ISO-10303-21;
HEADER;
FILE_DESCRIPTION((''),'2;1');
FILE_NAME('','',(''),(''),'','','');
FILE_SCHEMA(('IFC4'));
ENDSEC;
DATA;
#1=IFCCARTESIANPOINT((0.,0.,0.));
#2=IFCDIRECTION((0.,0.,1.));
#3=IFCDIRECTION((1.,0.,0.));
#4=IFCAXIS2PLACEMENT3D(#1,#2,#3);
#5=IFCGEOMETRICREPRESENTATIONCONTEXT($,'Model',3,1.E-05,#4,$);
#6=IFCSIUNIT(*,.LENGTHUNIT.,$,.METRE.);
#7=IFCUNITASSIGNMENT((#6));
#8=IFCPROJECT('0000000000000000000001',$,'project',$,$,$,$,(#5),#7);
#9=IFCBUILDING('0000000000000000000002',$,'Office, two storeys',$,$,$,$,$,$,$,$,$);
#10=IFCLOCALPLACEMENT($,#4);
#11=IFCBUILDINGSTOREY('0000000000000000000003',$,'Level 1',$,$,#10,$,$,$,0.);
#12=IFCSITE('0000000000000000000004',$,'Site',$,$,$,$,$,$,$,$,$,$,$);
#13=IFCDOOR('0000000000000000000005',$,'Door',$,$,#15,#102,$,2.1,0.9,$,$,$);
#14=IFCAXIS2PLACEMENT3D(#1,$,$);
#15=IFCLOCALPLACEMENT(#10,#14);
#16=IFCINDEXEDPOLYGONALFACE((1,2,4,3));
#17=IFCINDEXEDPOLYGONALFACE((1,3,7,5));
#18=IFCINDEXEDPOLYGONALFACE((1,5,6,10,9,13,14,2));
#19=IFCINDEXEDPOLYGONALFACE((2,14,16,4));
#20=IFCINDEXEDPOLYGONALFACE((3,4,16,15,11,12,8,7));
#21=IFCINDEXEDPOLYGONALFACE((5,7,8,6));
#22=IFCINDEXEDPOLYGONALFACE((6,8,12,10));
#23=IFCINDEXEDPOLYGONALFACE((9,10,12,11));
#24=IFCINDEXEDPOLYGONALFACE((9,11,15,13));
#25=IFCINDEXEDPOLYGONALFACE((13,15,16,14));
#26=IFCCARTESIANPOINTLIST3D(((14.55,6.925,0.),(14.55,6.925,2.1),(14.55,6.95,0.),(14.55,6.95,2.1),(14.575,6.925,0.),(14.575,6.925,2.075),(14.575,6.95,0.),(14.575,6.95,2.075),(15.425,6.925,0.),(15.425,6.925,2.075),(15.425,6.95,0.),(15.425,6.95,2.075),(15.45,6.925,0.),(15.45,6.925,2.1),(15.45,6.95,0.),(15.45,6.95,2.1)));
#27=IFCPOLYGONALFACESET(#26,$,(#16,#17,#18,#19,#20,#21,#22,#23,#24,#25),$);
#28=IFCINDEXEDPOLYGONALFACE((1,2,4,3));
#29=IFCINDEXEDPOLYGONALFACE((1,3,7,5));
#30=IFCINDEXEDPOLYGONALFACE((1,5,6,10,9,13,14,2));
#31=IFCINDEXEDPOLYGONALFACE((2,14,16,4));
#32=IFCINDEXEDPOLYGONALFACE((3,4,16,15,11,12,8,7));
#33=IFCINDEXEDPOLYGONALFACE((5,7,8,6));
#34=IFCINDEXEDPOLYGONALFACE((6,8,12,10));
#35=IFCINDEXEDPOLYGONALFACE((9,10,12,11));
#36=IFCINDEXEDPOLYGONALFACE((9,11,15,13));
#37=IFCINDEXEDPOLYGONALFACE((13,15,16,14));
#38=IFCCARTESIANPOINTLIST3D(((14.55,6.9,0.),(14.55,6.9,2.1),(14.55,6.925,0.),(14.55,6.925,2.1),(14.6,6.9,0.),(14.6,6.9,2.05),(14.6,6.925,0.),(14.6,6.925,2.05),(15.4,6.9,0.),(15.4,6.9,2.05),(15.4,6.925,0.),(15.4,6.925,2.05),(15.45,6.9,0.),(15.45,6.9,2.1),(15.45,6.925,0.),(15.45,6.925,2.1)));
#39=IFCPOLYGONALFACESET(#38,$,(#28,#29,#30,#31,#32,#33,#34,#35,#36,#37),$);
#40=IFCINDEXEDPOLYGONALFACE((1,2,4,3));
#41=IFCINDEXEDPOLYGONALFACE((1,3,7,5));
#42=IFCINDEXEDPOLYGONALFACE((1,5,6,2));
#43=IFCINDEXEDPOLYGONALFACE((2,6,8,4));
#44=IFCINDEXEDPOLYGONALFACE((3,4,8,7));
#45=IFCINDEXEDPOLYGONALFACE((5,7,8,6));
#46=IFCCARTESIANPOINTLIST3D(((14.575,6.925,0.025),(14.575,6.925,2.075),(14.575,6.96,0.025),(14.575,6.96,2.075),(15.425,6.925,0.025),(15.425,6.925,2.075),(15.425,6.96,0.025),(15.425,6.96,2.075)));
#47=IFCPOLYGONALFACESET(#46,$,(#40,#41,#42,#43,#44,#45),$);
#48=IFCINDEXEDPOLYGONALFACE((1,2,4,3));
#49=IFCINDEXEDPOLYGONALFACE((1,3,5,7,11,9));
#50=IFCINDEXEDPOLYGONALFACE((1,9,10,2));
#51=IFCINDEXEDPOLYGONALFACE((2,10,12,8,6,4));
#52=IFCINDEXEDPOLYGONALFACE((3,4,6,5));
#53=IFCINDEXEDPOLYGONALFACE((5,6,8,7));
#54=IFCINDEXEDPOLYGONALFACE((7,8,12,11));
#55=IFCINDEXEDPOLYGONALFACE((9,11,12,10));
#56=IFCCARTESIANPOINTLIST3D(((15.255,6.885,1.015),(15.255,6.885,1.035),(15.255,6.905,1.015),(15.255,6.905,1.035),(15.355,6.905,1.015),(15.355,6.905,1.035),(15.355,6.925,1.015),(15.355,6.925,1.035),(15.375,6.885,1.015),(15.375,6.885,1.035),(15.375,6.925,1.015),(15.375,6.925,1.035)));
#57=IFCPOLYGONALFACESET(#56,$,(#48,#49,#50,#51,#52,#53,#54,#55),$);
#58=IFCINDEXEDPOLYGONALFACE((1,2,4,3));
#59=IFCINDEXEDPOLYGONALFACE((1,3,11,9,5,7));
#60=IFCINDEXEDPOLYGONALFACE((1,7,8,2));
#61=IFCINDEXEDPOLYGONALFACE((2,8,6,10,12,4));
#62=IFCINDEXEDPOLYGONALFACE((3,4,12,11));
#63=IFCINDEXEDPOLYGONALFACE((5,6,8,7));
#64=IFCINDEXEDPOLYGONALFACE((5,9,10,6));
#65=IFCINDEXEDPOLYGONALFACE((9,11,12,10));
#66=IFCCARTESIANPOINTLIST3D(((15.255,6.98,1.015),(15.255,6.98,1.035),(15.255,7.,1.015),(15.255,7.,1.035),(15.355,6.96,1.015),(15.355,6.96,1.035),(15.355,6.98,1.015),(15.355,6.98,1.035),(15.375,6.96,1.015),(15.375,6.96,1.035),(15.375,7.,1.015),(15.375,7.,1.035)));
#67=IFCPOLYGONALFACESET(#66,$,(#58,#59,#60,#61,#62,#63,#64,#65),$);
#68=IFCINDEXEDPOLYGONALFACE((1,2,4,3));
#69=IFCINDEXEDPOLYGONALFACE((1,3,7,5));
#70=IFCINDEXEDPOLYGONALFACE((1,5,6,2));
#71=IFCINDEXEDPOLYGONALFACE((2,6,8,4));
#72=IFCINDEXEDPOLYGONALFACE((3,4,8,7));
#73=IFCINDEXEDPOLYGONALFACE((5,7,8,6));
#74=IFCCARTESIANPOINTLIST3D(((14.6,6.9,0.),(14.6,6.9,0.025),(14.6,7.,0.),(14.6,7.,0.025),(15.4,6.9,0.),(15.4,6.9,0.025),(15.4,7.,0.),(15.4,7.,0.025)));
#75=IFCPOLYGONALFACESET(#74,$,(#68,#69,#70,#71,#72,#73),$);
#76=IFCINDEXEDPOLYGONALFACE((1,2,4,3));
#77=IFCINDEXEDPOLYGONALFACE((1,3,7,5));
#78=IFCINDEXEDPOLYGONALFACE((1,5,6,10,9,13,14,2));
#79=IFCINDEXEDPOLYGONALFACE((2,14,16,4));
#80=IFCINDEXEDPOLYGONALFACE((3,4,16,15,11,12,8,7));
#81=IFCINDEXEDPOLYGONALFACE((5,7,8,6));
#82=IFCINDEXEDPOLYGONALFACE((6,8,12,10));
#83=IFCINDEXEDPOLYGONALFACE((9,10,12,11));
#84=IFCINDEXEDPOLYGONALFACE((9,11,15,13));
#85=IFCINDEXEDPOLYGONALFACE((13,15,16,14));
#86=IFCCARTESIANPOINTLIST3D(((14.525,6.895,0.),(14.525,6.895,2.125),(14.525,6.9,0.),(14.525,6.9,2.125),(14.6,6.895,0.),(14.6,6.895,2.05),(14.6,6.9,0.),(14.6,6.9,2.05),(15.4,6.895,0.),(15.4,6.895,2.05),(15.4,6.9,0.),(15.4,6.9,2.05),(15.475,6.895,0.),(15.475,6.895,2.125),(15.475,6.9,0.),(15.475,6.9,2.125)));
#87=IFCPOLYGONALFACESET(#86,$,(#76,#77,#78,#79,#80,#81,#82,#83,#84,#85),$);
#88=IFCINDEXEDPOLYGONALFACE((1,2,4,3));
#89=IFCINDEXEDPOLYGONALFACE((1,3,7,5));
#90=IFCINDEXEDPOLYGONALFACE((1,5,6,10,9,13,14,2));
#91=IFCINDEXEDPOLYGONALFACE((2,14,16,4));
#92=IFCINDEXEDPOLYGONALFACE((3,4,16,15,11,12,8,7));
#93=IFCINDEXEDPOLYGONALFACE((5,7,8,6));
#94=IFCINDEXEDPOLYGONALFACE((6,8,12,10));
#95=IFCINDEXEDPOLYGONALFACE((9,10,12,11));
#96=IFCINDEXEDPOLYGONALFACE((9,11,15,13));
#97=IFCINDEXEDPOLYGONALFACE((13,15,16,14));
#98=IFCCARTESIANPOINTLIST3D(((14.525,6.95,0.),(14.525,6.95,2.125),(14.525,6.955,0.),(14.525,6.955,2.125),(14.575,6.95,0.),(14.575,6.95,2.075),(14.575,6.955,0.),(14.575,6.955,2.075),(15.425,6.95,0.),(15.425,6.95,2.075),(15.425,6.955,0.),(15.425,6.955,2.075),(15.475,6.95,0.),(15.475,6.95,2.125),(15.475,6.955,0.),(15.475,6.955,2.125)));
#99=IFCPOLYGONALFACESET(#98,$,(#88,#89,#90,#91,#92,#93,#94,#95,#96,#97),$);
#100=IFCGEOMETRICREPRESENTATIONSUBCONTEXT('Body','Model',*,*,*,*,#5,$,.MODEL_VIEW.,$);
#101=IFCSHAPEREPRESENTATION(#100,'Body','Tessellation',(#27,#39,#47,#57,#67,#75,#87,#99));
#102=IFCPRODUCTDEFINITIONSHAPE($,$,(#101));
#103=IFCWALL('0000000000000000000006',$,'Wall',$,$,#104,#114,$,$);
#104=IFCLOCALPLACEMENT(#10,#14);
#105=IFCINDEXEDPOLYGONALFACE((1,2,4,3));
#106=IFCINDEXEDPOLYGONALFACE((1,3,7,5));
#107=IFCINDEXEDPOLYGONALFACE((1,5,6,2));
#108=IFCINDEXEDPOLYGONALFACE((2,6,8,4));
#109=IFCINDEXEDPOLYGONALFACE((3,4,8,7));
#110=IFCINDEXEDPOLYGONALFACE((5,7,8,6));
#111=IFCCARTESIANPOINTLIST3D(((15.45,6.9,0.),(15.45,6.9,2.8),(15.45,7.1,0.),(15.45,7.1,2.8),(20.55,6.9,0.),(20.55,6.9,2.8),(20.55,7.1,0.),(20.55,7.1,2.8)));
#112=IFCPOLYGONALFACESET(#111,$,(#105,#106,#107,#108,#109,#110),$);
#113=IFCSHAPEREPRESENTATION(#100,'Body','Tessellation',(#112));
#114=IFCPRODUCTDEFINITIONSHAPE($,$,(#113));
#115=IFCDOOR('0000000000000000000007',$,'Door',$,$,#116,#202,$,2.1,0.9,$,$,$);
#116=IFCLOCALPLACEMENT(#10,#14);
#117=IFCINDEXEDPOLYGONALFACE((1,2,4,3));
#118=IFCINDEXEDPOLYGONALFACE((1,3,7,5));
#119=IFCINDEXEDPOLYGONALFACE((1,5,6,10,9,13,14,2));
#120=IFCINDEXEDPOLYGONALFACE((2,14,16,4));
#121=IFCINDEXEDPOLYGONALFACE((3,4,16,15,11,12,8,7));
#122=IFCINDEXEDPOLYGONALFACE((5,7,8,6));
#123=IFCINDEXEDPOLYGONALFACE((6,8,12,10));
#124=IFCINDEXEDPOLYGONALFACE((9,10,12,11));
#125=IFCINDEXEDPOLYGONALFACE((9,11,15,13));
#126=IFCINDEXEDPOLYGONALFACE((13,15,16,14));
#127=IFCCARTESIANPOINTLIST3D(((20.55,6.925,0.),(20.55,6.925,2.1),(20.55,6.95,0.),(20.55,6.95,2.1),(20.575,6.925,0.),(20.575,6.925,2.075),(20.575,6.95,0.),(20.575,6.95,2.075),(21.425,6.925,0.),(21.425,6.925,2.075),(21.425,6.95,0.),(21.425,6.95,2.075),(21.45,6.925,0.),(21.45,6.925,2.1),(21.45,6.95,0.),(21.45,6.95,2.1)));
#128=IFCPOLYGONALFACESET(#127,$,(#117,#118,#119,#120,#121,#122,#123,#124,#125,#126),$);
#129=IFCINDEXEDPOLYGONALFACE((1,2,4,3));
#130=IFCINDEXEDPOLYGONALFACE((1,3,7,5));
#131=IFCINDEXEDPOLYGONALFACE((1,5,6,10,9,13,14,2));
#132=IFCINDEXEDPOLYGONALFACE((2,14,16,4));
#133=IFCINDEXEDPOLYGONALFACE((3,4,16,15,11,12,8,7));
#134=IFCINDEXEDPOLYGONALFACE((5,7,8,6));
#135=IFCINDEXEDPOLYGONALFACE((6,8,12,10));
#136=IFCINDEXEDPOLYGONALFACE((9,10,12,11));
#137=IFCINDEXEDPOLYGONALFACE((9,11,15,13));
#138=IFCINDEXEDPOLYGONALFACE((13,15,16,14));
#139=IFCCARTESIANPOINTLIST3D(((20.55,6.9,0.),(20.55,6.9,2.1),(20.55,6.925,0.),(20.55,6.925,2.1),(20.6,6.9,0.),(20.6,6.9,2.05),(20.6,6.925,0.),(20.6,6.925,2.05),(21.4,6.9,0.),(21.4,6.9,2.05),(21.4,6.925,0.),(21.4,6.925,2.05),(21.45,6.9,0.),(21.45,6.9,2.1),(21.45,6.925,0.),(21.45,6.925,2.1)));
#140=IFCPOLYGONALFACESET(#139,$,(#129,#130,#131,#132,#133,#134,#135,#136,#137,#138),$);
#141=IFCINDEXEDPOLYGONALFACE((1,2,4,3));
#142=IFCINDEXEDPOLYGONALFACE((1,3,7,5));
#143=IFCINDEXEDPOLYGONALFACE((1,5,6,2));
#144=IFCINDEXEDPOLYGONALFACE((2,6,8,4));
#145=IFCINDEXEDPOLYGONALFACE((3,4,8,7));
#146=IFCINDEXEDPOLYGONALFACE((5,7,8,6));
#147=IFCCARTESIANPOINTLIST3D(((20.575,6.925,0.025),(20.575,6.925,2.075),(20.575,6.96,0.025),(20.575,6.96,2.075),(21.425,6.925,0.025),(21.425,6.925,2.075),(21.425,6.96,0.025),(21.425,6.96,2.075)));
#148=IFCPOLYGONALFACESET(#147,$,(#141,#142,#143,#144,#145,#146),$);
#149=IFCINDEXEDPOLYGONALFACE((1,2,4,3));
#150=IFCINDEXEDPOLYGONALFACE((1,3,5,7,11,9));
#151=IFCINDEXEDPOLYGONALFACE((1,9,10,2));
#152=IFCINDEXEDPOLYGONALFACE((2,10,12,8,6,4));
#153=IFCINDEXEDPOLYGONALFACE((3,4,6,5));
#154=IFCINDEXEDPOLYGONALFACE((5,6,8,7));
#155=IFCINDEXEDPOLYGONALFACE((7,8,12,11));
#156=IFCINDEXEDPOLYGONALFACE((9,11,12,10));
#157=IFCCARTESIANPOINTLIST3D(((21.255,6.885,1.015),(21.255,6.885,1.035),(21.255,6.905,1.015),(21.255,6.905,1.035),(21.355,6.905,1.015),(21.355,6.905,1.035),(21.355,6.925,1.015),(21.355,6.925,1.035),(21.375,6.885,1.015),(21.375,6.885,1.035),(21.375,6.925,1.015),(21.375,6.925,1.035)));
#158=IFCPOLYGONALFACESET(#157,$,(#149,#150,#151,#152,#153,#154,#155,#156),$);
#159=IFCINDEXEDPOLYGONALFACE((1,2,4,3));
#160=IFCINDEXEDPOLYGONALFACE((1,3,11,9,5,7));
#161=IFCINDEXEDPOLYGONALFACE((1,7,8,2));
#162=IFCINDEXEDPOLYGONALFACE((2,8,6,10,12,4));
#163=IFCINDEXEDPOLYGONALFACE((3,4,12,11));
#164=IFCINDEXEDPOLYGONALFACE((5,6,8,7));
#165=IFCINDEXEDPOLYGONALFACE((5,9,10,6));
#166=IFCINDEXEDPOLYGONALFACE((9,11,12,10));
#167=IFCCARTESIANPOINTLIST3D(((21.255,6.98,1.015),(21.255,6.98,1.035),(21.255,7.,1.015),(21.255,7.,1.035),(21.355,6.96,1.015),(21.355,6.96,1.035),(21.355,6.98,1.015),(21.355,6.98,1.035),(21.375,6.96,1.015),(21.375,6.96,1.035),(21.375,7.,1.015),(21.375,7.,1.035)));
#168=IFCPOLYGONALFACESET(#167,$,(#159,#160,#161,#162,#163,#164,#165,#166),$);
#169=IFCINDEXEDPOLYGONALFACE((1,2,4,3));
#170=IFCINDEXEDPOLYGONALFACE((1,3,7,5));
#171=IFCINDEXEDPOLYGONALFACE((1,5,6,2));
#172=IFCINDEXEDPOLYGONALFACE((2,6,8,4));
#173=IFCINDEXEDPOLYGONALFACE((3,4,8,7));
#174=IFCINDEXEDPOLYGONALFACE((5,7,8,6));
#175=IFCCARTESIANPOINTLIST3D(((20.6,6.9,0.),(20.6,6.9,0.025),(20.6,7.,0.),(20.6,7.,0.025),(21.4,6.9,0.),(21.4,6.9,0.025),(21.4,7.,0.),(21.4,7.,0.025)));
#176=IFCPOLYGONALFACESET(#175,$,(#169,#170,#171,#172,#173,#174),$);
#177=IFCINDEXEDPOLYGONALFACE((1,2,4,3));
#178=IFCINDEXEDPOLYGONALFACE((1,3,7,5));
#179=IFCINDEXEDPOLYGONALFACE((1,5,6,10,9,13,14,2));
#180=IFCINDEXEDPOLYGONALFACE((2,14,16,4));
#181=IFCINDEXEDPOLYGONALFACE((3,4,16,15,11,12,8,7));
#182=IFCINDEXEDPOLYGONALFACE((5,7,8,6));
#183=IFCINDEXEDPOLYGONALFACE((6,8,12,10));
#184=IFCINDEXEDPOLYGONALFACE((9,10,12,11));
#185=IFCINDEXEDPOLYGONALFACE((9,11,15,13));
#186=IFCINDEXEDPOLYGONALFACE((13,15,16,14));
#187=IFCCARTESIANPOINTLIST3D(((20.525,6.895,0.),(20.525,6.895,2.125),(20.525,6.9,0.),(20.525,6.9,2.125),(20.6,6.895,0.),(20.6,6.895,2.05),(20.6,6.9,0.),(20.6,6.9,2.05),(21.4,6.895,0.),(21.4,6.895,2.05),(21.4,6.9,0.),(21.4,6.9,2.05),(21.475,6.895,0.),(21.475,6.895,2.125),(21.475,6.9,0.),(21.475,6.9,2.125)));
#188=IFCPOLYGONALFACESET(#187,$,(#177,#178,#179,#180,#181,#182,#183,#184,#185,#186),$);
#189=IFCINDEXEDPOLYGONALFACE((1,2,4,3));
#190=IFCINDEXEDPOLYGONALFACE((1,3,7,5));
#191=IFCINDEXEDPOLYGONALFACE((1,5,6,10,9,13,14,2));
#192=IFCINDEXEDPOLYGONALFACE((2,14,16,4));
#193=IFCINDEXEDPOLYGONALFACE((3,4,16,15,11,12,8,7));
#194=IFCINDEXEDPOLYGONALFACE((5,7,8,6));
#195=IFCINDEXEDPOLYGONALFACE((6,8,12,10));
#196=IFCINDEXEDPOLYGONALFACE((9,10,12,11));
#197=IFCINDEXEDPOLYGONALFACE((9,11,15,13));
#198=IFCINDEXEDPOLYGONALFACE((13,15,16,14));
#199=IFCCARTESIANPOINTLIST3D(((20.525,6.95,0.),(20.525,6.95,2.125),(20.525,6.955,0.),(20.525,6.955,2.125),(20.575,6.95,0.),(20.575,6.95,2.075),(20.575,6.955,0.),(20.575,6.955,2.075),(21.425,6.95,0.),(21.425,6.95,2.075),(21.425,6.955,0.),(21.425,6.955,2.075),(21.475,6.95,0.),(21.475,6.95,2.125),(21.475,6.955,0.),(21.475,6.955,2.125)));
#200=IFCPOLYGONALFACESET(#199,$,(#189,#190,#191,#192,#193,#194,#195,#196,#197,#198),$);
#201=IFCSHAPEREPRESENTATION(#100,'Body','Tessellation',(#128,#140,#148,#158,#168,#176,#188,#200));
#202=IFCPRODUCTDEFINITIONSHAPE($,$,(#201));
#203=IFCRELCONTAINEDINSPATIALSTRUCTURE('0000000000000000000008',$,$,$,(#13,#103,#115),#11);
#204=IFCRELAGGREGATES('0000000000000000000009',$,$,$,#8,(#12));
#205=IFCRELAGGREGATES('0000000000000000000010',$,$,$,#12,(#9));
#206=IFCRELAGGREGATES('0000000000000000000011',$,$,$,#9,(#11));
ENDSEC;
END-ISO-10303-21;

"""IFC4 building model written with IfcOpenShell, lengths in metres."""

from ifc_helpers import new_model, si_unit, frame, origin_with_axes, place, context, subcontext, project, spatial, line, indexed_curve, outline, extrude, element, save


model = new_model("IFC4")

# Units and contexts
model_context = context("Model", 3, precision=1e-05, world=origin_with_axes())
body_context = subcontext(model_context, "Body", "Model", "MODEL_VIEW")
ifc_project = project(units=[si_unit("LENGTHUNIT", "METRE")], contexts=[model_context])

# Site, building, storey
site = spatial("IfcSite", under=ifc_project, Name="Site")
building = spatial("IfcBuilding", under=site, Name="Office, two storeys")
storey_placement = place(None, origin_with_axes())
storey = spatial("IfcBuildingStorey", under=building, at=storey_placement, Name="Level 1", Elevation=0.0)

# Door
door_1_placement = place(storey_placement, frame((14.55, 6.9, 0.0), z_axis=(0.0, 0.0, 1.0), x_axis=(1.0, 0.0, 0.0)))
element("IfcDoor", 1, at=door_1_placement, inside=storey, Name="Door", OverallHeight=2.1, OverallWidth=0.9, context=body_context, shape_type="SweptSolid", body=[
    extrude(outline(indexed_curve([(0.0, 0.0), (0.0, 2.1), (0.9, 2.1), (0.9, 0.0), (0.875, 0.0), (0.875, 2.075), (0.025, 2.075), (0.025, 0.0)], segments=[line(1, 2, 3, 4, 5, 6, 7, 8, 1)])), frame((0.0, 0.025, 0.0), z_axis=(0.0, -1.0, 0.0), x_axis=(1.0, 0.0, 0.0)), (0.0, 0.0, -1.0), 0.025),
    extrude(outline(indexed_curve([(0.0, 0.0), (0.0, 2.1), (0.9, 2.1), (0.9, 0.0), (0.85, 0.0), (0.85, 2.05), (0.05, 2.05), (0.05, 0.0)], segments=[line(1, 2, 3, 4, 5, 6, 7, 8, 1)])), frame((0.0, 0.0, 0.0), z_axis=(0.0, -1.0, 0.0), x_axis=(1.0, 0.0, 0.0)), (0.0, 0.0, -1.0), 0.025),
    extrude(outline(indexed_curve([(0.0, 0.0), (0.85, 0.0), (0.85, 0.035), (0.0, 0.035)], segments=[line(1, 2, 3, 4, 1)])), frame((0.025, 0.025, 0.025), z_axis=(0.0, 0.0, 1.0), x_axis=(1.0, 0.0, 0.0)), (0.0, 0.0, 1.0), 2.05),
    extrude(outline(indexed_curve([(0.0, 0.0), (0.0, -0.04), (-0.12, -0.04), (-0.12, -0.02), (-0.02, -0.02), (-0.02, 0.0)], segments=[line(1, 2, 3, 4, 5, 6, 1)])), frame((0.825, 0.025, 1.015), z_axis=(0.0, 0.0, 1.0), x_axis=(1.0, 0.0, 0.0)), (0.0, 0.0, 1.0), 0.02),
    extrude(outline(indexed_curve([(0.0, 0.0), (0.0, 0.04), (-0.12, 0.04), (-0.12, 0.02), (-0.02, 0.02), (-0.02, 0.0)], segments=[line(1, 2, 3, 4, 5, 6, 1)])), frame((0.825, 0.06, 1.015), z_axis=(0.0, 0.0, 1.0), x_axis=(1.0, 0.0, 0.0)), (0.0, 0.0, 1.0), 0.02),
    extrude(outline(indexed_curve([(0.0, 0.0), (0.8, 0.0), (0.8, 0.1), (0.0, 0.1)], segments=[line(1, 2, 3, 4, 1)])), frame((0.05, 0.0, 0.0), z_axis=(0.0, 0.0, 1.0), x_axis=(1.0, 0.0, 0.0)), (0.0, 0.0, 1.0), 0.025),
    extrude(outline(indexed_curve([(0.0, 0.0), (0.0, 2.125), (0.95, 2.125), (0.95, 0.0), (0.875, 0.0), (0.875, 2.05), (0.075, 2.05), (0.075, 0.0)], segments=[line(1, 2, 3, 4, 5, 6, 7, 8, 1)])), frame((-0.025, -0.005, 0.0), z_axis=(0.0, -1.0, 0.0), x_axis=(1.0, 0.0, 0.0)), (0.0, 0.0, -1.0), 0.005),
    extrude(outline(indexed_curve([(0.0, 0.0), (0.0, 2.125), (0.95, 2.125), (0.95, 0.0), (0.9, 0.0), (0.9, 2.075), (0.05, 2.075), (0.05, 0.0)], segments=[line(1, 2, 3, 4, 5, 6, 7, 8, 1)])), frame((-0.025, 0.05, 0.0), z_axis=(0.0, -1.0, 0.0), x_axis=(1.0, 0.0, 0.0)), (0.0, 0.0, -1.0), 0.005),
])

# Wall
wall_1_placement = place(storey_placement, frame((15.45, 7.0, 0.0), z_axis=(0.0, 0.0, 1.0), x_axis=(1.0, 0.0, 0.0)))
element("IfcWall", 2, at=wall_1_placement, inside=storey, Name="Wall", context=body_context, shape_type="SweptSolid", body=[
    extrude(outline(indexed_curve([(0.0, 0.0), (0.0, 0.2), (5.1, 0.2), (5.1, 0.0), (0.0, 0.0)], self_intersect=False)), frame((0.0, -0.1, 0.0), z_axis=(0.0, 0.0, 1.0), x_axis=(1.0, 0.0, 0.0)), (0.0, 0.0, 1.0), 2.8),
])

# Door
door_2_placement = place(storey_placement, frame((20.55, 6.9, 0.0), z_axis=(0.0, 0.0, 1.0), x_axis=(1.0, 0.0, 0.0)))
element("IfcDoor", 3, at=door_2_placement, inside=storey, Name="Door", OverallHeight=2.1, OverallWidth=0.9, context=body_context, shape_type="SweptSolid", body=[
    extrude(outline(indexed_curve([(0.0, 0.0), (0.0, 2.1), (0.9, 2.1), (0.9, 0.0), (0.875, 0.0), (0.875, 2.075), (0.025, 2.075), (0.025, 0.0)], segments=[line(1, 2, 3, 4, 5, 6, 7, 8, 1)])), frame((0.0, 0.025, 0.0), z_axis=(0.0, -1.0, 0.0), x_axis=(1.0, 0.0, 0.0)), (0.0, 0.0, -1.0), 0.025),
    extrude(outline(indexed_curve([(0.0, 0.0), (0.0, 2.1), (0.9, 2.1), (0.9, 0.0), (0.85, 0.0), (0.85, 2.05), (0.05, 2.05), (0.05, 0.0)], segments=[line(1, 2, 3, 4, 5, 6, 7, 8, 1)])), frame((0.0, 0.0, 0.0), z_axis=(0.0, -1.0, 0.0), x_axis=(1.0, 0.0, 0.0)), (0.0, 0.0, -1.0), 0.025),
    extrude(outline(indexed_curve([(0.0, 0.0), (0.85, 0.0), (0.85, 0.035), (0.0, 0.035)], segments=[line(1, 2, 3, 4, 1)])), frame((0.025, 0.025, 0.025), z_axis=(0.0, 0.0, 1.0), x_axis=(1.0, 0.0, 0.0)), (0.0, 0.0, 1.0), 2.05),
    extrude(outline(indexed_curve([(0.0, 0.0), (0.0, -0.04), (-0.12, -0.04), (-0.12, -0.02), (-0.02, -0.02), (-0.02, 0.0)], segments=[line(1, 2, 3, 4, 5, 6, 1)])), frame((0.825, 0.025, 1.015), z_axis=(0.0, 0.0, 1.0), x_axis=(1.0, 0.0, 0.0)), (0.0, 0.0, 1.0), 0.02),
    extrude(outline(indexed_curve([(0.0, 0.0), (0.0, 0.04), (-0.12, 0.04), (-0.12, 0.02), (-0.02, 0.02), (-0.02, 0.0)], segments=[line(1, 2, 3, 4, 5, 6, 1)])), frame((0.825, 0.06, 1.015), z_axis=(0.0, 0.0, 1.0), x_axis=(1.0, 0.0, 0.0)), (0.0, 0.0, 1.0), 0.02),
    extrude(outline(indexed_curve([(0.0, 0.0), (0.8, 0.0), (0.8, 0.1), (0.0, 0.1)], segments=[line(1, 2, 3, 4, 1)])), frame((0.05, 0.0, 0.0), z_axis=(0.0, 0.0, 1.0), x_axis=(1.0, 0.0, 0.0)), (0.0, 0.0, 1.0), 0.025),
    extrude(outline(indexed_curve([(0.0, 0.0), (0.0, 2.125), (0.95, 2.125), (0.95, 0.0), (0.875, 0.0), (0.875, 2.05), (0.075, 2.05), (0.075, 0.0)], segments=[line(1, 2, 3, 4, 5, 6, 7, 8, 1)])), frame((-0.025, -0.005, 0.0), z_axis=(0.0, -1.0, 0.0), x_axis=(1.0, 0.0, 0.0)), (0.0, 0.0, -1.0), 0.005),
    extrude(outline(indexed_curve([(0.0, 0.0), (0.0, 2.125), (0.95, 2.125), (0.95, 0.0), (0.9, 0.0), (0.9, 2.075), (0.05, 2.075), (0.05, 0.0)], segments=[line(1, 2, 3, 4, 5, 6, 7, 8, 1)])), frame((-0.025, 0.05, 0.0), z_axis=(0.0, -1.0, 0.0), x_axis=(1.0, 0.0, 0.0)), (0.0, 0.0, -1.0), 0.005),
])

save(model, "model.ifc")
